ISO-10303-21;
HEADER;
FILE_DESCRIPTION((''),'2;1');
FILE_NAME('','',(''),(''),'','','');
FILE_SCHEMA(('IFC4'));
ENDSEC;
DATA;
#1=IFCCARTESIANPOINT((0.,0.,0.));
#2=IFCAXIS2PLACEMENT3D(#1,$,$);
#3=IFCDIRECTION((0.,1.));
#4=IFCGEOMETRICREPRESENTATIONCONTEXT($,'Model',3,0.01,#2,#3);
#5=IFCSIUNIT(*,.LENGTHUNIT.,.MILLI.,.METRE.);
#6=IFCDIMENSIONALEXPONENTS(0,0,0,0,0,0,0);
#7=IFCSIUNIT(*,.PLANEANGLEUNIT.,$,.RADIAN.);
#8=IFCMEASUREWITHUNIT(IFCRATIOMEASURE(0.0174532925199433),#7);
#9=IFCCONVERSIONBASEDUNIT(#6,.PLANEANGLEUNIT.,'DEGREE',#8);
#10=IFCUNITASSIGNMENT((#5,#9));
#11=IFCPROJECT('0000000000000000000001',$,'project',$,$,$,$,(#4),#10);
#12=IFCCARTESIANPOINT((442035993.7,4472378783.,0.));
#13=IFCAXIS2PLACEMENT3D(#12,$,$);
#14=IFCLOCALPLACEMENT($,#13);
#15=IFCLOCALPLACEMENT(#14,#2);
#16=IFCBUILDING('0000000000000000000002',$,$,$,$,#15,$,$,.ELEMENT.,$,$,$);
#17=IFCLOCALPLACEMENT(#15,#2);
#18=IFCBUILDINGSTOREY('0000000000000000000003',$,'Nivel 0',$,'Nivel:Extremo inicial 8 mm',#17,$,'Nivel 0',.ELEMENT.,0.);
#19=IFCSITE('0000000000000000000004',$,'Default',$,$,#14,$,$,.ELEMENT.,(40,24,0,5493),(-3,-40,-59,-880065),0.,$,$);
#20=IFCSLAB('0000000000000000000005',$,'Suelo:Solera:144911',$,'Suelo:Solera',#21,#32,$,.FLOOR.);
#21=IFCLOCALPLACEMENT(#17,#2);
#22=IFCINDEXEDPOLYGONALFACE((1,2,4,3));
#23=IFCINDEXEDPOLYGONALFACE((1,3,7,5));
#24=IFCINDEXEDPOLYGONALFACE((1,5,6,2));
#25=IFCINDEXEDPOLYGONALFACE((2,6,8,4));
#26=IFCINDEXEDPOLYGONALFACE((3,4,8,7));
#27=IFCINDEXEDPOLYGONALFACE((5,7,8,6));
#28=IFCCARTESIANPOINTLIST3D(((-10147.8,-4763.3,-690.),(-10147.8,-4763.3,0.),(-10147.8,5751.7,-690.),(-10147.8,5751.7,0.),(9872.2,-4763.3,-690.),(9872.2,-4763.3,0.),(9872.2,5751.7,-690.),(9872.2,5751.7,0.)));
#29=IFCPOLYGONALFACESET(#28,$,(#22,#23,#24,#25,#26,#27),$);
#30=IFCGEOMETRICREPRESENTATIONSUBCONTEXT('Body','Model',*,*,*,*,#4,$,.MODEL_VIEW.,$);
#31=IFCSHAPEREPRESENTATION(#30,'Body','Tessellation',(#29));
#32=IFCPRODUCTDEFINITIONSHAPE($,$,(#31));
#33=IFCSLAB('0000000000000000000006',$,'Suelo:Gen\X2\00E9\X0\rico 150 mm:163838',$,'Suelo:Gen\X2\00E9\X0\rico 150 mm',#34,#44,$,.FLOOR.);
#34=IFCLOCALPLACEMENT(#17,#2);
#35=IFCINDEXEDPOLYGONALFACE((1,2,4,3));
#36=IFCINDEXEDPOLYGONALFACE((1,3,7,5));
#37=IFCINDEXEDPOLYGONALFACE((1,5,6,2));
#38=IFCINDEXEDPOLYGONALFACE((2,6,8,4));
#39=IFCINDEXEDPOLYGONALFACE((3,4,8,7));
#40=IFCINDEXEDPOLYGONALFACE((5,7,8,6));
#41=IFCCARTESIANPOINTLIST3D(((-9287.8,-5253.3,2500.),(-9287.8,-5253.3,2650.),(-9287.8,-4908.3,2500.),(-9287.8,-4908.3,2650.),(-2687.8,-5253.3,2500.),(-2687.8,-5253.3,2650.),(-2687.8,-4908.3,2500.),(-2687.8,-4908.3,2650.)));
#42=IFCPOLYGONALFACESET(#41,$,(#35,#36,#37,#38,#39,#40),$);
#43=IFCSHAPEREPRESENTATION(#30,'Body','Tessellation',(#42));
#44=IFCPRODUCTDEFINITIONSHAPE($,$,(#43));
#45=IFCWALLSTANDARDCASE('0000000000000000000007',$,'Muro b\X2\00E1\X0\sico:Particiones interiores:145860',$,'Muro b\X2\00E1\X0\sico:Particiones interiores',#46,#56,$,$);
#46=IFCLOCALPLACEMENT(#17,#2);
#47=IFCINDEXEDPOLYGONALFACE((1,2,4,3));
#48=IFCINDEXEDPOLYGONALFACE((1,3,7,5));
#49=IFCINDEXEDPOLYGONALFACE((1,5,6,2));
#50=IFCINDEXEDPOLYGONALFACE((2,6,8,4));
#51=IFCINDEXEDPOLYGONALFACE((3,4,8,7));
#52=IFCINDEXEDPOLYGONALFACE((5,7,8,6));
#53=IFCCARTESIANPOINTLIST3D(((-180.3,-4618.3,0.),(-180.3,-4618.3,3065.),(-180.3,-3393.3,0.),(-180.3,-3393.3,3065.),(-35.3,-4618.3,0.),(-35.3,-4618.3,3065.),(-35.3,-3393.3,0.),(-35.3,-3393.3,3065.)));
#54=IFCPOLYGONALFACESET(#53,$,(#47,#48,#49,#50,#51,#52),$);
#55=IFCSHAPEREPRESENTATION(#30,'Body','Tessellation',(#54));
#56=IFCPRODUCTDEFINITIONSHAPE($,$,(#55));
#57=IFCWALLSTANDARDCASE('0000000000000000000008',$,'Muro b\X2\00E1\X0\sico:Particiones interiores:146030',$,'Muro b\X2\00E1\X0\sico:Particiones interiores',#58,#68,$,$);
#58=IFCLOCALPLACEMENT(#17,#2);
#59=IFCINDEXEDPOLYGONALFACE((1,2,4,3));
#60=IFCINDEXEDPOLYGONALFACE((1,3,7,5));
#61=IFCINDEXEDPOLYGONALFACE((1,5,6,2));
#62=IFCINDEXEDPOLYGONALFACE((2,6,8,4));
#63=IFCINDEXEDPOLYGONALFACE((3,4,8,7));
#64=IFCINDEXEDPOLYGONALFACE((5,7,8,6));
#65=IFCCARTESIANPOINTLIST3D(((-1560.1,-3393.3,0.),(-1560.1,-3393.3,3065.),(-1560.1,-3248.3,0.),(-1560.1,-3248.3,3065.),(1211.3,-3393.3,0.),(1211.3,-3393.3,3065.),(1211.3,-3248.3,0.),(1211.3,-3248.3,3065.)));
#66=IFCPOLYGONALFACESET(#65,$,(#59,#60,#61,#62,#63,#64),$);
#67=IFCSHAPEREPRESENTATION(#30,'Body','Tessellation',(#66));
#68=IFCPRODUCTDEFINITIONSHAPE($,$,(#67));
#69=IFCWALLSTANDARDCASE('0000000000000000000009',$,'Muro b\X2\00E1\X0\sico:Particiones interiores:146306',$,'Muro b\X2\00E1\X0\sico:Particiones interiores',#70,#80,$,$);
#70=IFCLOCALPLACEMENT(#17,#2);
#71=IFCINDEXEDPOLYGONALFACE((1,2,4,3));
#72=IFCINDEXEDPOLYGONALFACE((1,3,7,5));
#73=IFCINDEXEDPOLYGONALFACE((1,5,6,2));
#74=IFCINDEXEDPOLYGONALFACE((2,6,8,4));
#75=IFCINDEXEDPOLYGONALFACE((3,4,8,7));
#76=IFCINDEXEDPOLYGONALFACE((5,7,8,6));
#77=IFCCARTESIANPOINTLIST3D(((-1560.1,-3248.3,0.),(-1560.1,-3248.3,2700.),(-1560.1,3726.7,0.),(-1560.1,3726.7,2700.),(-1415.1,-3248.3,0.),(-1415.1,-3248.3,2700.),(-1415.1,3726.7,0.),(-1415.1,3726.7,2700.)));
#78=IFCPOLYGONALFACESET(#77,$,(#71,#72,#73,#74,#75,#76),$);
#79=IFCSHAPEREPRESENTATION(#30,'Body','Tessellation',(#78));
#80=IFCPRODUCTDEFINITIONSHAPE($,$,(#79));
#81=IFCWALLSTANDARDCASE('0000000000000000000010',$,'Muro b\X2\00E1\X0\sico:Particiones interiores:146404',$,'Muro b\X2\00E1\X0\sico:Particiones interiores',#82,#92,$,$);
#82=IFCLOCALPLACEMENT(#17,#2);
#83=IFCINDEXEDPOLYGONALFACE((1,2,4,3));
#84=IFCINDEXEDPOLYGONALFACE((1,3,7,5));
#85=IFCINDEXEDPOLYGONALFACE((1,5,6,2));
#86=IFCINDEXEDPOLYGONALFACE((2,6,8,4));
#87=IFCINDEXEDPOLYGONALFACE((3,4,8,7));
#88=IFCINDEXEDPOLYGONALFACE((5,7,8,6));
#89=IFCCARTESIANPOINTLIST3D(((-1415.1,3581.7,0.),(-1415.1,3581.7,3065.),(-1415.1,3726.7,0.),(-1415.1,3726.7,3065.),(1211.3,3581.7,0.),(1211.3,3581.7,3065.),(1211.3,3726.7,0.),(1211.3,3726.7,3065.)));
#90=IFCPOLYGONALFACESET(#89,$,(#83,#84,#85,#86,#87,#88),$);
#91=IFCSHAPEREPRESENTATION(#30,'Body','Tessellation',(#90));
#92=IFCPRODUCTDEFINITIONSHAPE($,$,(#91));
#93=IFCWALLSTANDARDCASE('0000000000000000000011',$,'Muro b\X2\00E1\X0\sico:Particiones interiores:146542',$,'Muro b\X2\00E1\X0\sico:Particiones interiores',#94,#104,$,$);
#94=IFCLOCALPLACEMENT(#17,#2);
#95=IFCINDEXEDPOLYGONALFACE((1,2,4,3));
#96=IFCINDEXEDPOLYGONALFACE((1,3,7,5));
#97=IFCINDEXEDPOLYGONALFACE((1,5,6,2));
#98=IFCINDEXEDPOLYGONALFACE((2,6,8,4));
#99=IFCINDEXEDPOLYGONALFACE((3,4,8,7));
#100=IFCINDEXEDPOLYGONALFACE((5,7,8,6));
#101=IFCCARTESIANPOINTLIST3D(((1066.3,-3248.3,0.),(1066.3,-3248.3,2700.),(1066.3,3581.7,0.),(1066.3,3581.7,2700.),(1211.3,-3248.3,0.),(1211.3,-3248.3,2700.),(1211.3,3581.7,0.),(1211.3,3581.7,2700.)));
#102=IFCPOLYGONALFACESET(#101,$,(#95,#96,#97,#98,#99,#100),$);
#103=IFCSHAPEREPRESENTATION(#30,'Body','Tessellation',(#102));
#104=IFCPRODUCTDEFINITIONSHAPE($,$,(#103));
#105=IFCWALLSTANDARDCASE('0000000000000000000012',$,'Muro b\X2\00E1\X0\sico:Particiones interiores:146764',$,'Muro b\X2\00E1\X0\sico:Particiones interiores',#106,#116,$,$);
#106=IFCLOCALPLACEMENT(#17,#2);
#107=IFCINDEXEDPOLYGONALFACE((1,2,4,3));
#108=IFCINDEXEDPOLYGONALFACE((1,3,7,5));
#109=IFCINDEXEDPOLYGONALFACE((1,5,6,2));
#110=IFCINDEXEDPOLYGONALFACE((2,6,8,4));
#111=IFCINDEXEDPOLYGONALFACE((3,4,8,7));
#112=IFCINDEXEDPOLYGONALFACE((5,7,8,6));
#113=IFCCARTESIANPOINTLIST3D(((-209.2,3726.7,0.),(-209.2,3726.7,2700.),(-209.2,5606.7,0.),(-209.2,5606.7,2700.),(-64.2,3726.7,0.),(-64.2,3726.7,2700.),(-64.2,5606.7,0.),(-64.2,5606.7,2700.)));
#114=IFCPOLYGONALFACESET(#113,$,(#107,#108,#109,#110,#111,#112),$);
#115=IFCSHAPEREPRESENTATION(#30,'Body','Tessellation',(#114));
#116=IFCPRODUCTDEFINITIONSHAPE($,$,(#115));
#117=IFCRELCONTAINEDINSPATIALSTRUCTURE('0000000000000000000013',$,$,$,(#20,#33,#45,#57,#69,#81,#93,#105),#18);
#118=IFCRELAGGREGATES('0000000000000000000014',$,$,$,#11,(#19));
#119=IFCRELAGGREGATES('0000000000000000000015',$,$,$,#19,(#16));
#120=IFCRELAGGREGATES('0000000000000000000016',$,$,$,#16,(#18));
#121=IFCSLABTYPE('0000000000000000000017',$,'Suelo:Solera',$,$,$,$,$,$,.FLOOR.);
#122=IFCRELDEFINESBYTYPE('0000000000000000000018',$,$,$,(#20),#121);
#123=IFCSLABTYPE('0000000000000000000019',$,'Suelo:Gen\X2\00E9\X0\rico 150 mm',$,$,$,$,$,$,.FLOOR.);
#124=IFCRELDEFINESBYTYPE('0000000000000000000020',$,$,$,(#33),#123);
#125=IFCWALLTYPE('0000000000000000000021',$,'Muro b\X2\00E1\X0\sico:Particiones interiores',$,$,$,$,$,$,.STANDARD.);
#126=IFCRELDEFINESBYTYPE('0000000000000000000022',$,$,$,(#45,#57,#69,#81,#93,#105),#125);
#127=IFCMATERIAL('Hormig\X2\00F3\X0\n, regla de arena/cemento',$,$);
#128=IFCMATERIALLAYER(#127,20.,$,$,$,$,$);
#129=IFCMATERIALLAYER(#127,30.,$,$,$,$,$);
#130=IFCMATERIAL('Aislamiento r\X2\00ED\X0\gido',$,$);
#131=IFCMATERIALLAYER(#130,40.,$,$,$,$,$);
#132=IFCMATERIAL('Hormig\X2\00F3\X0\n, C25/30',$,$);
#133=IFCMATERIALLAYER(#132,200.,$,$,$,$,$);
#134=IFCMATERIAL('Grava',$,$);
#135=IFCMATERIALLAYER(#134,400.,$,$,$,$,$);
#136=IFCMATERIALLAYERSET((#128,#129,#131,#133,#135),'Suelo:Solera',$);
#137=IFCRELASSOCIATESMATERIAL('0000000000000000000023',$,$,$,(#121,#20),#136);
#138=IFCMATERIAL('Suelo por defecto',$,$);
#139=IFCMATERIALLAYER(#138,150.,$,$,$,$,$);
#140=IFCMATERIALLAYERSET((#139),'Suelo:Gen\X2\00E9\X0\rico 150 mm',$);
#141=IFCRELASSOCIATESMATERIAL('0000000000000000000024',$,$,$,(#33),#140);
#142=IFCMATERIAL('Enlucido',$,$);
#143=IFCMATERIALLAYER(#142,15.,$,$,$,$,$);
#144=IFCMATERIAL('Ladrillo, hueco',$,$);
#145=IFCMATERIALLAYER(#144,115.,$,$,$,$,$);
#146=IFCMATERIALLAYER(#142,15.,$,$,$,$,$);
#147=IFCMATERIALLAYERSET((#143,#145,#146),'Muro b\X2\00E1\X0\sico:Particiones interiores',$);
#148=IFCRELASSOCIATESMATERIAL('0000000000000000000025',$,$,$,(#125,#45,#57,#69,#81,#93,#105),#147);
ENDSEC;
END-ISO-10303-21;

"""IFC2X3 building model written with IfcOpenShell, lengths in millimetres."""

from ifc_helpers import new_model, entity, si_unit, converted_unit, direction, frame, frame_2d, origin, place, context, subcontext, project, spatial, polyline, rectangle, extrude, clip, bounded_halfspace, material, layer, layer_set, layer_usage, type_object, element, save


model = new_model("IFC2X3")

# Units and contexts
model_context = context("Model", 3, precision=0.01, world=origin(), true_north=direction((0.0, 1.0)))
body_context = subcontext(model_context, "Body", "Model", "MODEL_VIEW")
ifc_project = project(units=[si_unit("LENGTHUNIT", "METRE", prefix="MILLI"), converted_unit("PLANEANGLEUNIT", "DEGREE", entity("IfcRatioMeasure", 0.0174532925199433), si_unit("PLANEANGLEUNIT", "RADIAN"), dimensions=[0, 0, 0, 0, 0, 0, 0])], contexts=[model_context])

# Site, building, storey
site_placement = place(None, frame((442035993.7, 4472378783.0, 0.0)))
site = spatial("IfcSite", under=ifc_project, at=site_placement, Name="Default", CompositionType="ELEMENT", RefLatitude=(40, 24, 0, 5493), RefLongitude=(-3, -40, -59, -880065), RefElevation=0.0)
building_placement = place(site_placement, origin())
building = spatial("IfcBuilding", under=site, at=building_placement, CompositionType="ELEMENT")
storey_placement = place(building_placement, origin())
storey = spatial("IfcBuildingStorey", under=building, at=storey_placement, Name="Nivel 0", ObjectType="Nivel:Extremo inicial 8 mm", LongName="Nivel 0", CompositionType="ELEMENT", Elevation=0.0)

# Slabs
ifc_material_1 = material(Name="Hormigón, regla de arena/cemento")
ifc_layer_1 = layer(ifc_material_1, 20.0)
ifc_layer_2 = layer(ifc_material_1, 30.0)
ifc_material_2 = material(Name="Aislamiento rígido")
ifc_layer_3 = layer(ifc_material_2, 40.0)
ifc_material_3 = material(Name="Hormigón, C25/30")
ifc_layer_4 = layer(ifc_material_3, 200.0)
ifc_material_4 = material(Name="Grava")
ifc_layer_5 = layer(ifc_material_4, 400.0)
ifc_layer_set_1 = layer_set([ifc_layer_1, ifc_layer_2, ifc_layer_3, ifc_layer_4, ifc_layer_5], Name="Suelo:Solera")
ifc_layer_usage_1 = layer_usage(ifc_layer_set_1, "AXIS3", "POSITIVE", 0.0)
slab_type_1 = type_object("IfcSlabType", Name="Suelo:Solera", PredefinedType="FLOOR", material=ifc_layer_set_1)
slab_1_placement = place(storey_placement, origin())
element("IfcSlab", 1, at=slab_1_placement, inside=storey, type_object=slab_type_1, material=ifc_layer_usage_1, Name="Suelo:Solera:144911", ObjectType="Suelo:Solera", PredefinedType="FLOOR", context=body_context, shape_type="SweptSolid", body=[
    extrude(rectangle(XDim=10515.0, YDim=20020.0, at=frame_2d((0.0, 0.0), x_axis=(1.0, 0.0))), frame((-137.8, 494.2, 0.0), z_axis=(0.0, 0.0, -1.0), x_axis=(0.0, 1.0, 0.0)), (0.0, 0.0, 1.0), 690.0),
])
ifc_material_5 = material(Name="Suelo por defecto")
ifc_layer_6 = layer(ifc_material_5, 150.0)
ifc_layer_set_2 = layer_set([ifc_layer_6], Name="Suelo:Genérico 150 mm")
ifc_layer_usage_2 = layer_usage(ifc_layer_set_2, "AXIS3", "POSITIVE", 0.0)
slab_type_2 = type_object("IfcSlabType", Name="Suelo:Genérico 150 mm", PredefinedType="FLOOR")
slab_2_placement = place(storey_placement, frame((-9287.8, -5253.3, 2500.0)))
element("IfcSlab", 2, at=slab_2_placement, inside=storey, type_object=slab_type_2, material=ifc_layer_usage_2, Name="Suelo:Genérico 150 mm:163838", ObjectType="Suelo:Genérico 150 mm", PredefinedType="FLOOR", context=body_context, shape_type="SweptSolid", body=[
    extrude(rectangle(XDim=6600.0, YDim=345.0, at=frame_2d((5850.0, 0.0), x_axis=(1.0, 0.0))), frame((9150.0, 172.5, 150.0), z_axis=(0.0, 0.0, -1.0), x_axis=(-1.0, 0.0, 0.0)), (0.0, 0.0, 1.0), 150.0),
])

# Walls
ifc_material_6 = material(Name="Enlucido")
ifc_layer_7 = layer(ifc_material_6, 15.0)
ifc_material_7 = material(Name="Ladrillo, hueco")
ifc_layer_8 = layer(ifc_material_7, 115.0)
ifc_layer_9 = layer(ifc_material_6, 15.0)
ifc_layer_set_3 = layer_set([ifc_layer_7, ifc_layer_8, ifc_layer_9], Name="Muro básico:Particiones interiores")
ifc_layer_usage_3 = layer_usage(ifc_layer_set_3, "AXIS2", "NEGATIVE", 72.5)
wall_type = type_object("IfcWallType", Name="Muro básico:Particiones interiores", PredefinedType="STANDARD", material=ifc_layer_set_3)
wall_1_placement = place(storey_placement, frame((-107.8, -4618.3, 0.0), z_axis=(0.0, 0.0, 1.0), x_axis=(0.0, 1.0, 0.0)))
element("IfcWallStandardCase", 3, at=wall_1_placement, inside=storey, type_object=wall_type, material=ifc_layer_usage_3, Name="Muro básico:Particiones interiores:145860", ObjectType="Muro básico:Particiones interiores", context=body_context, shape_type="SweptSolid", body=[
    extrude(rectangle(XDim=1225.0, YDim=145.0, at=frame_2d((612.5, 0.0), x_axis=(-1.0, 0.0))), origin(), (0.0, 0.0, 1.0), 3065.0),
])
ifc_layer_usage_4 = layer_usage(ifc_layer_set_3, "AXIS2", "NEGATIVE", 72.5)
wall_2_placement = place(storey_placement, frame((1211.3, -3320.8, 0.0), z_axis=(0.0, 0.0, 1.0), x_axis=(-1.0, 0.0, 0.0)))
element("IfcWallStandardCase", 4, at=wall_2_placement, inside=storey, type_object=wall_type, material=ifc_layer_usage_4, Name="Muro básico:Particiones interiores:146030", ObjectType="Muro básico:Particiones interiores", context=body_context, shape_type="SweptSolid", body=[
    extrude(rectangle(XDim=2771.4, YDim=145.0, at=frame_2d((1385.7, 0.0), x_axis=(-1.0, 0.0))), origin(), (0.0, 0.0, 1.0), 3065.0),
])
ifc_layer_usage_5 = layer_usage(ifc_layer_set_3, "AXIS2", "NEGATIVE", 72.5)
wall_3_placement = place(storey_placement, frame((-1487.6, -3248.3, 0.0), z_axis=(0.0, 0.0, 1.0), x_axis=(0.0, 1.0, 0.0)))
element("IfcWallStandardCase", 5, at=wall_3_placement, inside=storey, type_object=wall_type, material=ifc_layer_usage_5, Name="Muro básico:Particiones interiores:146306", ObjectType="Muro básico:Particiones interiores", context=body_context, shape_type="Clipping", body=[
    clip(extrude(rectangle(XDim=6975.0, YDim=145.0, at=frame_2d((3487.5, 0.0), x_axis=(-1.0, 0.0))), origin(), (0.0, 0.0, 1.0), 2700.0), bounded_halfspace(frame((0.0, -72.5, 2700.0), z_axis=(0.0, 0.0, -1.0), x_axis=(0.0, 1.0, 0.0)), True, frame((0.0, -72.5, 2700.0), z_axis=(0.0, 0.0, -1.0), x_axis=(0.0, 1.0, 0.0)), polyline([(0.0, 0.0), (145.0, 0.0), (145.0, 6975.0), (0.0, 6975.0), (0.0, 0.0)]))),
])
ifc_layer_usage_6 = layer_usage(ifc_layer_set_3, "AXIS2", "NEGATIVE", 72.5)
wall_4_placement = place(storey_placement, frame((-1415.1, 3654.2, 0.0)))
element("IfcWallStandardCase", 6, at=wall_4_placement, inside=storey, type_object=wall_type, material=ifc_layer_usage_6, Name="Muro básico:Particiones interiores:146404", ObjectType="Muro básico:Particiones interiores", context=body_context, shape_type="SweptSolid", body=[
    extrude(rectangle(XDim=2626.4, YDim=145.0, at=frame_2d((1313.2, 0.0), x_axis=(-1.0, 0.0))), origin(), (0.0, 0.0, 1.0), 3065.0),
])
ifc_layer_usage_7 = layer_usage(ifc_layer_set_3, "AXIS2", "NEGATIVE", 72.5)
wall_5_placement = place(storey_placement, frame((1138.8, 3581.7, 0.0), z_axis=(0.0, 0.0, 1.0), x_axis=(0.0, -1.0, 0.0)))
element("IfcWallStandardCase", 7, at=wall_5_placement, inside=storey, type_object=wall_type, material=ifc_layer_usage_7, Name="Muro básico:Particiones interiores:146542", ObjectType="Muro básico:Particiones interiores", context=body_context, shape_type="Clipping", body=[
    clip(extrude(rectangle(XDim=6830.0, YDim=145.0, at=frame_2d((3415.0, 0.0), x_axis=(-1.0, 0.0))), origin(), (0.0, 0.0, 1.0), 2700.0), bounded_halfspace(frame((0.0, -72.5, 2700.0), z_axis=(0.0, 0.0, -1.0), x_axis=(0.0, -1.0, 0.0)), True, frame((0.0, -72.5, 2700.0), z_axis=(0.0, 0.0, -1.0), x_axis=(0.0, -1.0, 0.0)), polyline([(0.0, 0.0), (-145.0, 0.0), (-145.0, -6830.0), (0.0, -6830.0), (0.0, 0.0)]))),
])
ifc_layer_usage_8 = layer_usage(ifc_layer_set_3, "AXIS2", "NEGATIVE", 72.5)
wall_6_placement = place(storey_placement, frame((-136.7, 3726.7, 0.0), z_axis=(0.0, 0.0, 1.0), x_axis=(0.0, 1.0, 0.0)))
element("IfcWallStandardCase", 8, at=wall_6_placement, inside=storey, type_object=wall_type, material=ifc_layer_usage_8, Name="Muro básico:Particiones interiores:146764", ObjectType="Muro básico:Particiones interiores", context=body_context, shape_type="Clipping", body=[
    clip(extrude(rectangle(XDim=1880.0, YDim=145.0, at=frame_2d((940.0, 0.0), x_axis=(-1.0, 0.0))), origin(), (0.0, 0.0, 1.0), 2700.0), bounded_halfspace(frame((0.0, -72.5, 2700.0), z_axis=(0.0, 0.0, -1.0), x_axis=(0.0, 1.0, 0.0)), True, frame((0.0, -72.5, 2700.0), z_axis=(0.0, 0.0, -1.0), x_axis=(0.0, 1.0, 0.0)), polyline([(0.0, 0.0), (145.0, 0.0), (145.0, 1880.0), (0.0, 1880.0), (0.0, 0.0)]))),
])

save(model, "model.ifc")
